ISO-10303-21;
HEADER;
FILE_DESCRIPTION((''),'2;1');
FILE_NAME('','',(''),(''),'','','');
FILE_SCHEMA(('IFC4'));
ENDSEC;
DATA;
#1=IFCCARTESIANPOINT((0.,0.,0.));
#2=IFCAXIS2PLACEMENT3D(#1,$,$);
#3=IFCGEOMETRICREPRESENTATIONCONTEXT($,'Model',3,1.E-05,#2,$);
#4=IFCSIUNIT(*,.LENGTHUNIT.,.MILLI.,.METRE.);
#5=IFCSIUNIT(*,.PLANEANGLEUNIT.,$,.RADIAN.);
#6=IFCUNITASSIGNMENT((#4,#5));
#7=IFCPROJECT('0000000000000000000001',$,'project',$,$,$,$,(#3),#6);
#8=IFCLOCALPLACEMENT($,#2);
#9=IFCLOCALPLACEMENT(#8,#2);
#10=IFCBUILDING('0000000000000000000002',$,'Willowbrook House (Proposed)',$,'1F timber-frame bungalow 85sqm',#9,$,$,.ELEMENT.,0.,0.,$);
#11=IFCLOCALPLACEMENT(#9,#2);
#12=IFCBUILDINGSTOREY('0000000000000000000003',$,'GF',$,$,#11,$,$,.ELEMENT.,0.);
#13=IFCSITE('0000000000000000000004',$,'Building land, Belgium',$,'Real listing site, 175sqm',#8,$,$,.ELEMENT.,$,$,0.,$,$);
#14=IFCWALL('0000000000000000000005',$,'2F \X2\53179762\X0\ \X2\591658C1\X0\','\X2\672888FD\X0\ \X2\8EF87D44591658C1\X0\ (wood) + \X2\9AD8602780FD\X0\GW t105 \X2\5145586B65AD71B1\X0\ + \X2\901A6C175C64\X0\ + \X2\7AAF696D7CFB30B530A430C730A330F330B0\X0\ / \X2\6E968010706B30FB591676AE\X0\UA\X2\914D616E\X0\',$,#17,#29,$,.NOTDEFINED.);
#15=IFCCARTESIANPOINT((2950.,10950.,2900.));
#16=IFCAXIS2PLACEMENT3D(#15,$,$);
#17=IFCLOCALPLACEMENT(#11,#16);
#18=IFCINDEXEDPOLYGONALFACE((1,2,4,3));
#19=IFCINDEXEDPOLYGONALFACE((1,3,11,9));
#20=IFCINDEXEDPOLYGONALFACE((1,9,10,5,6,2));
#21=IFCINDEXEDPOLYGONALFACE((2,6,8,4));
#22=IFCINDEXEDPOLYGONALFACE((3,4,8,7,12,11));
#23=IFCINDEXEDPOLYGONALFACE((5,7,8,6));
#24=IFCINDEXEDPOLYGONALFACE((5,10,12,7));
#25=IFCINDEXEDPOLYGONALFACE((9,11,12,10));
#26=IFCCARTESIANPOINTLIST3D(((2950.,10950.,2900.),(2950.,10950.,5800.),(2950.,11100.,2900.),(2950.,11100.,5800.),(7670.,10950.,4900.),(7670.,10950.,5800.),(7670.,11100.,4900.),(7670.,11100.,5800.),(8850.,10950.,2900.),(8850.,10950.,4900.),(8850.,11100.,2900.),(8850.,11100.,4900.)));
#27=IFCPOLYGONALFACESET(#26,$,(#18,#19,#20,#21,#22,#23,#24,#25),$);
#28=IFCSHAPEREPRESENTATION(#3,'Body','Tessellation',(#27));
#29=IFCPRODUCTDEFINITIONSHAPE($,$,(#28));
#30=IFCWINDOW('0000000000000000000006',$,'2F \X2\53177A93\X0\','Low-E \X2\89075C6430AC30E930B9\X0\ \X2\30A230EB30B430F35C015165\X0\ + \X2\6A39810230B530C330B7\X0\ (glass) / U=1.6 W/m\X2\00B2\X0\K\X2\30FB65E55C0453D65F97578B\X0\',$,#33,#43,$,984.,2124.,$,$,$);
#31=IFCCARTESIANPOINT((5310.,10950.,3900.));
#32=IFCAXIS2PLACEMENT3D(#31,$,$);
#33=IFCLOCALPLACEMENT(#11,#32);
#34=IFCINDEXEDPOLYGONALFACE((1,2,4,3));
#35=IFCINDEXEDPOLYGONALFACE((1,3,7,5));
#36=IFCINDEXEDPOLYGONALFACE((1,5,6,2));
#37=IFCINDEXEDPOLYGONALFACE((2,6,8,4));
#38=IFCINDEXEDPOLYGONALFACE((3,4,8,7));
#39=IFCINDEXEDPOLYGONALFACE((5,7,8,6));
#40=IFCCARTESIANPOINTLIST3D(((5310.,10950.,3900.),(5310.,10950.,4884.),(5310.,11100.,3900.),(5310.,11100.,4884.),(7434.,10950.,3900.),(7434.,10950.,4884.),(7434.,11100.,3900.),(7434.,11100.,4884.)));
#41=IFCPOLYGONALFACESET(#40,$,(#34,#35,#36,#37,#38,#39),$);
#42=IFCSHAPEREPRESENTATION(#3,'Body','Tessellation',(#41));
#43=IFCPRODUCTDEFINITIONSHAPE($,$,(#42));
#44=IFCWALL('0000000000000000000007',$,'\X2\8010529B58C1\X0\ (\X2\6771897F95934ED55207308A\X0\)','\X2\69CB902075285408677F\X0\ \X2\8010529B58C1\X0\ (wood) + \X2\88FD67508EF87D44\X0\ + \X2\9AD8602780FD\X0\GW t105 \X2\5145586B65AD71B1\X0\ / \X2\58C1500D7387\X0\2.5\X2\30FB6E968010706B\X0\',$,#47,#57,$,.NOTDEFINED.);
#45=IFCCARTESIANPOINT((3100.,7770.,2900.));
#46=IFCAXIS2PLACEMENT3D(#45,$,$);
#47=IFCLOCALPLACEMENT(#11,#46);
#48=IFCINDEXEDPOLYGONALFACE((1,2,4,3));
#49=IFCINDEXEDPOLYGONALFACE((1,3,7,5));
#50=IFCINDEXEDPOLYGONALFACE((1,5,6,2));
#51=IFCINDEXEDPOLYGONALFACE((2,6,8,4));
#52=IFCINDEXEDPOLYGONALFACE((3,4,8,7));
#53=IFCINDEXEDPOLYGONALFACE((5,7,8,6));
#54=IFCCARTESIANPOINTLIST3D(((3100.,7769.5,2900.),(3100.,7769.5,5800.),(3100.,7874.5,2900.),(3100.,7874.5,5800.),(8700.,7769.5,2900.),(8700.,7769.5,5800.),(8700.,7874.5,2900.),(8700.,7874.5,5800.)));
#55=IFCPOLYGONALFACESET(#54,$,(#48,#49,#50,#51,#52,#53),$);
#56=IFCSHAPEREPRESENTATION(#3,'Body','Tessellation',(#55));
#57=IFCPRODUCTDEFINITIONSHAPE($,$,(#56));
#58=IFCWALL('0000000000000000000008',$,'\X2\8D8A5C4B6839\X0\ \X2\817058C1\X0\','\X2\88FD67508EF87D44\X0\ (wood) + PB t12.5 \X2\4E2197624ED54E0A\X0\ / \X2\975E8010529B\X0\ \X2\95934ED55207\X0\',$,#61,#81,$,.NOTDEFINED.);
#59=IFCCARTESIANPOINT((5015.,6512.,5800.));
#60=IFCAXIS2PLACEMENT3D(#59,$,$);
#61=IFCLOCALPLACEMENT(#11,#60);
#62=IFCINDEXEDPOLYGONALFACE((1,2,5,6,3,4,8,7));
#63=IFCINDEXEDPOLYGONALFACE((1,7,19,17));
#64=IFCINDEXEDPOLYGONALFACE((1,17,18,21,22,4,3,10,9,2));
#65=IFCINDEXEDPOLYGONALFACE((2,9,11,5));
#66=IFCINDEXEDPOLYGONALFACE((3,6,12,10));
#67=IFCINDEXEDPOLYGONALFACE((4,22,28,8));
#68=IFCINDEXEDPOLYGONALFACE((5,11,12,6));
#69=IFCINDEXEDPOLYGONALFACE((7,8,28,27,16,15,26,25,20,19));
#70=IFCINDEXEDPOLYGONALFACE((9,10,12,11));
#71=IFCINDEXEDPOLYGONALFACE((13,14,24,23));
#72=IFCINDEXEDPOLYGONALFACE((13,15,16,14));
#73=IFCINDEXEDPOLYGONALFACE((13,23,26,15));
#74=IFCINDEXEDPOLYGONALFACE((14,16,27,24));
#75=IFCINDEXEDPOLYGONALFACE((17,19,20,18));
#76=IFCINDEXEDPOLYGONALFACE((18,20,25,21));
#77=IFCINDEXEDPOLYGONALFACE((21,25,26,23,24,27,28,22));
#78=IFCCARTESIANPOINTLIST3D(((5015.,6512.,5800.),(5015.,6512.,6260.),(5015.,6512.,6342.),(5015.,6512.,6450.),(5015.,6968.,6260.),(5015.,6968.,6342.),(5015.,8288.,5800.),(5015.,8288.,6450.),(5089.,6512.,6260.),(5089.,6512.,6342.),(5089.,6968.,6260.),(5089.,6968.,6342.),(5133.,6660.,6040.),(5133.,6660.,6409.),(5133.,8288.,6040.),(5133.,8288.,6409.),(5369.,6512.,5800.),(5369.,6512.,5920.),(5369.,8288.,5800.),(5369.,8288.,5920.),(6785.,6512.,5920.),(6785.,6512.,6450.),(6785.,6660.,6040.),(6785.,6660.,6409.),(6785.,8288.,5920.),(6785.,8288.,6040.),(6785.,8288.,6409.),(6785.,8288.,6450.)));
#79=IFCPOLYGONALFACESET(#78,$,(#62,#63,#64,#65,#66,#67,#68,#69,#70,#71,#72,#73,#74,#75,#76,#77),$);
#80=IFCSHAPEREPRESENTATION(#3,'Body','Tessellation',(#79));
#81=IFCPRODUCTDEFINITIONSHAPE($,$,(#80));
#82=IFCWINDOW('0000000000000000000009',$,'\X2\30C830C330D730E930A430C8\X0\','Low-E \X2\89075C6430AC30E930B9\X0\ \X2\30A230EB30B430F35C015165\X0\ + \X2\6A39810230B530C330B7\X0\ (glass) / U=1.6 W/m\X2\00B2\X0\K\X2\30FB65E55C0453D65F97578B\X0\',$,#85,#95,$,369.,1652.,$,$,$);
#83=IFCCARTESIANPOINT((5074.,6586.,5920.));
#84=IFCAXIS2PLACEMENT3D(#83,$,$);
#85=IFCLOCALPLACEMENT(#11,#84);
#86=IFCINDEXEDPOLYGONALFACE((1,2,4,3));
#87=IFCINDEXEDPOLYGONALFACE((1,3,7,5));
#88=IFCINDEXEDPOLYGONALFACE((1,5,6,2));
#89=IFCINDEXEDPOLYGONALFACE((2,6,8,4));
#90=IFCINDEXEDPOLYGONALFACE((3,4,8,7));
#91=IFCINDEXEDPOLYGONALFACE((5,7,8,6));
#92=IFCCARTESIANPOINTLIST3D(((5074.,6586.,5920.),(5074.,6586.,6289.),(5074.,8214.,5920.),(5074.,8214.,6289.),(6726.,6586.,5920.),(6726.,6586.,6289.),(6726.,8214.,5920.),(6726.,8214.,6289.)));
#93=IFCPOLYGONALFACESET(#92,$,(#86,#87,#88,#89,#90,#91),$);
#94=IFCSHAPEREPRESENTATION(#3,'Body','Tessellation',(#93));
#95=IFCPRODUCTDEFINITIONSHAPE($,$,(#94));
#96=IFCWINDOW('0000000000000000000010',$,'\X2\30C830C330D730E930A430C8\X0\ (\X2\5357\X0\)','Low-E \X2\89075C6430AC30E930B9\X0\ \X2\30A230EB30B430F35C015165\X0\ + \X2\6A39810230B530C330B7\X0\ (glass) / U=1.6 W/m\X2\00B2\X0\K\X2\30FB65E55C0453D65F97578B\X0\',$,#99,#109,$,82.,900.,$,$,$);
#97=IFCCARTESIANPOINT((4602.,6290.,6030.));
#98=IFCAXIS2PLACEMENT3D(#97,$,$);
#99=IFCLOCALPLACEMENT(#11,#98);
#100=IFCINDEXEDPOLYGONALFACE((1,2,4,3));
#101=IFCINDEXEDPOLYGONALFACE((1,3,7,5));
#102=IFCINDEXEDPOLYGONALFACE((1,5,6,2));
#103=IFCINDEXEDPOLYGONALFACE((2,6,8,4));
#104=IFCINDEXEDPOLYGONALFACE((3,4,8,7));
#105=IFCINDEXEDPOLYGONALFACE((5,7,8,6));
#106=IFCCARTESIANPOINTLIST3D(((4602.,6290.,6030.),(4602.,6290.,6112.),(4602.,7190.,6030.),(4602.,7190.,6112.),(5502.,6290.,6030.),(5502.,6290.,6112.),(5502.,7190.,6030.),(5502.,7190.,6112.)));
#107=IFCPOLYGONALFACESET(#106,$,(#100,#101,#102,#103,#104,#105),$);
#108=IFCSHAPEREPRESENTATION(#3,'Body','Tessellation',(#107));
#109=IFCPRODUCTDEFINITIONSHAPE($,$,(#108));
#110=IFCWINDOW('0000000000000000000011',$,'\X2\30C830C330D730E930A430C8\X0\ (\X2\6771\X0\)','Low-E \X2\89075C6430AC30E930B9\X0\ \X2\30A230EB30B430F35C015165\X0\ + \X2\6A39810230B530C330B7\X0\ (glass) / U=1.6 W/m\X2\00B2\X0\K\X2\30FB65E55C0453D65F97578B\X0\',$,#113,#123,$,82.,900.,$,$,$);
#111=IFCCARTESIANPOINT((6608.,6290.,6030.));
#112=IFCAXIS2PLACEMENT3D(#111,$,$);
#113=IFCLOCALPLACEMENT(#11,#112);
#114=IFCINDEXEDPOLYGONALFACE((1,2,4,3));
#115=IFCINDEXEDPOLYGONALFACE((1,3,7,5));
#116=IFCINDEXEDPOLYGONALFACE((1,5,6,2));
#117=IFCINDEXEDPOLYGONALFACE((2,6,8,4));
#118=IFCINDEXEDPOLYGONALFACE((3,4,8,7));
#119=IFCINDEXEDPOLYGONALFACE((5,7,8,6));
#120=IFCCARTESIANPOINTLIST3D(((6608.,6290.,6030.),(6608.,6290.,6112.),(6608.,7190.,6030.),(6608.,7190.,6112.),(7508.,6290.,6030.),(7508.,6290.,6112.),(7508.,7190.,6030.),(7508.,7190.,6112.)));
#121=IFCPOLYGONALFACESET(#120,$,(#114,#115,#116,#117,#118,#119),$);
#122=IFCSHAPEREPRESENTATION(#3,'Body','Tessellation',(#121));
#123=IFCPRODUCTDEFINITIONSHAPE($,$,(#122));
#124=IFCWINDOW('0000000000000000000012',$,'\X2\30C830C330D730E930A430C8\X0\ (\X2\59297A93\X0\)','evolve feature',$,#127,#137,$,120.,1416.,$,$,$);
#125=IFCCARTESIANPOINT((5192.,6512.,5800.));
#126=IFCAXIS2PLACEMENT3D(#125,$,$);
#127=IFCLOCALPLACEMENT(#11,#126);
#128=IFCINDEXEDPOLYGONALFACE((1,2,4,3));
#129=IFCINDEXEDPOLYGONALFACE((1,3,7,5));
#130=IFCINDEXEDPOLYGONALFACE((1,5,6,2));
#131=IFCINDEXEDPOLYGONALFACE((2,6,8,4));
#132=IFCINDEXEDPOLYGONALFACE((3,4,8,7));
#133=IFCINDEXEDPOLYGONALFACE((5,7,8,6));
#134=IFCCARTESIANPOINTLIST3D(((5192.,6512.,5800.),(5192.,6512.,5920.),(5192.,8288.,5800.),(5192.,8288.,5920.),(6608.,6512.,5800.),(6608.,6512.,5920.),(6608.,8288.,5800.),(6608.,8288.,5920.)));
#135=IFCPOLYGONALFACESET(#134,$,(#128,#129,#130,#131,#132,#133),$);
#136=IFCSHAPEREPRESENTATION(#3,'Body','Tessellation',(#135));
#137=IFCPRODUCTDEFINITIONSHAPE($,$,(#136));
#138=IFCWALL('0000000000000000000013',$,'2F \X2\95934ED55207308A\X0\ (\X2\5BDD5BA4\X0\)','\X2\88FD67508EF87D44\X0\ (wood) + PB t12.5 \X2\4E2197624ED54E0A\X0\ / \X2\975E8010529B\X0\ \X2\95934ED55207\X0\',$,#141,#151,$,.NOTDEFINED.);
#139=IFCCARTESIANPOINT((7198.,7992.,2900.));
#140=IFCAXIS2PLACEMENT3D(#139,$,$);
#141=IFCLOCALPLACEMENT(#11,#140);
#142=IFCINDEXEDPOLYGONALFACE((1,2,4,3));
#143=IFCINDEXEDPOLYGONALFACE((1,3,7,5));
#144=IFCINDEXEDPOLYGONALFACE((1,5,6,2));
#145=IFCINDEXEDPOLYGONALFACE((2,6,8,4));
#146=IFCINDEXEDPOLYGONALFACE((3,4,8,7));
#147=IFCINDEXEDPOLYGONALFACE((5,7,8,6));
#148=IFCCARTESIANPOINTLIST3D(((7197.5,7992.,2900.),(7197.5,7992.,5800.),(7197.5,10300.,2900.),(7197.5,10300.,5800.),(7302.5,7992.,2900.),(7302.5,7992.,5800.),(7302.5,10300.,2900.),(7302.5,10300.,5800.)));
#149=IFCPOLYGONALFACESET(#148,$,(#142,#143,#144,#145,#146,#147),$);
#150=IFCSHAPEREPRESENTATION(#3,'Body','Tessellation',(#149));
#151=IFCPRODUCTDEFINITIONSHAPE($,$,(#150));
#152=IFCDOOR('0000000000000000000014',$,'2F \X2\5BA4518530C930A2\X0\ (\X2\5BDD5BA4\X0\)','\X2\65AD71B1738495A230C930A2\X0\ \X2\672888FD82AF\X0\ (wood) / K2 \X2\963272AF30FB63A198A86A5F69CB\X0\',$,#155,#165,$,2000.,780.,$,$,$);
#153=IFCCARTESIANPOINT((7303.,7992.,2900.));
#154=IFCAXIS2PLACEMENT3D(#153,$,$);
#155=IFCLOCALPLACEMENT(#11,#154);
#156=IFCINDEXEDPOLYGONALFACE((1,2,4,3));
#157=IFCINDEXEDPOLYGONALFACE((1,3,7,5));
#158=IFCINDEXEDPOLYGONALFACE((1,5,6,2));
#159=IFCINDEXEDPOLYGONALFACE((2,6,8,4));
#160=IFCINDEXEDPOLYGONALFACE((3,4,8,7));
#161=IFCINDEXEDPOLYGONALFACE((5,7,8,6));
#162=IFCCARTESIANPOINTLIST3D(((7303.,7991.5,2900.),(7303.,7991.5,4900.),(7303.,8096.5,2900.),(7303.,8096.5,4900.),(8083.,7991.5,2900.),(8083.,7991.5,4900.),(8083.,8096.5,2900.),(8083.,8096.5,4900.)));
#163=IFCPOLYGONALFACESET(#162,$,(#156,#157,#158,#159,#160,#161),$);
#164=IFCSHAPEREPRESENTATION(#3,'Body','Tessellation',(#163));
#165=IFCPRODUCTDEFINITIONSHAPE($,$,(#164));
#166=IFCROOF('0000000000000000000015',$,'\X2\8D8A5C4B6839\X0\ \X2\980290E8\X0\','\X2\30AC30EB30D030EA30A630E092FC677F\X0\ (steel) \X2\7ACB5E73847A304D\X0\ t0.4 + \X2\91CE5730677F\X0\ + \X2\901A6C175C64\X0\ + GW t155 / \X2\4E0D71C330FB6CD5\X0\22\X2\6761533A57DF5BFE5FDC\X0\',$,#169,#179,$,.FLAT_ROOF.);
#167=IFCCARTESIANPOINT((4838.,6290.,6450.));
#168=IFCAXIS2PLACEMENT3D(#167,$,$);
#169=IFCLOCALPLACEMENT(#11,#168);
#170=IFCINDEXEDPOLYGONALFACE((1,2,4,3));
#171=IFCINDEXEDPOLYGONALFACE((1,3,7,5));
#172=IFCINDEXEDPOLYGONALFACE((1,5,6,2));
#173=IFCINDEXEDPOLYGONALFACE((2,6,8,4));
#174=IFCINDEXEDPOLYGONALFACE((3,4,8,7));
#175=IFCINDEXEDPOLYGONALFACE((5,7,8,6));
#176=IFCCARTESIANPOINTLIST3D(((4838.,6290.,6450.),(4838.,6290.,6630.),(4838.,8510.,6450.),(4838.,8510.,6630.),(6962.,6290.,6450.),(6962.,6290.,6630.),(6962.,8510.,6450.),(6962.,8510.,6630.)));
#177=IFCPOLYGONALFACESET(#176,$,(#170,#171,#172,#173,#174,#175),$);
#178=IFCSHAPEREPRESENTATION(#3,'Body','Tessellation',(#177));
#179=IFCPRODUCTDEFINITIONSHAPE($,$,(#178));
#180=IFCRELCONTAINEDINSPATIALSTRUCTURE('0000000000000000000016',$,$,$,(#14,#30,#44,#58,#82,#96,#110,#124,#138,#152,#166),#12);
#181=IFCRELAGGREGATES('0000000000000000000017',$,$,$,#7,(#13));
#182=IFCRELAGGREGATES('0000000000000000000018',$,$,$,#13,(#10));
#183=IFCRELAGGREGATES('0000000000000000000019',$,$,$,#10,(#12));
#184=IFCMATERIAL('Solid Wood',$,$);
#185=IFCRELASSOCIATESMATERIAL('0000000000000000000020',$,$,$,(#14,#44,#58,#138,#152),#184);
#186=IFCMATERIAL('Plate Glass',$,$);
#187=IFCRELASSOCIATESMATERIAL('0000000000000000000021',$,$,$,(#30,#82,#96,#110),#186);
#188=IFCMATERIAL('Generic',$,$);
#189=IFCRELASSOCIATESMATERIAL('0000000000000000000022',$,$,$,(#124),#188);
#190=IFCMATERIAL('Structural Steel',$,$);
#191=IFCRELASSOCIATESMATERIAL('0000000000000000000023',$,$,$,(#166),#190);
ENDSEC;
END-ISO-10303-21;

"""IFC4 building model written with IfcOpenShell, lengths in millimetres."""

from ifc_helpers import new_model, si_unit, frame, frame_2d, origin, place, context, project, spatial, rectangle, extrude, material, element, fill, save


model = new_model("IFC4")

# Units and contexts
model_context = context("Model", 3, precision=1e-05, world=origin())
ifc_project = project(units=[si_unit("LENGTHUNIT", "METRE", prefix="MILLI"), si_unit("PLANEANGLEUNIT", "RADIAN")], contexts=[model_context])

# Site, building, storey
site_placement = place(None, origin())
site = spatial("IfcSite", under=ifc_project, at=site_placement, Name="Building land, Belgium", ObjectType="Real listing site, 175sqm", CompositionType="ELEMENT", RefElevation=0.0)
building_placement = place(site_placement, origin())
building = spatial("IfcBuilding", under=site, at=building_placement, Name="Willowbrook House (Proposed)", ObjectType="1F timber-frame bungalow 85sqm", CompositionType="ELEMENT", ElevationOfRefHeight=0.0, ElevationOfTerrain=0.0)
storey_placement = place(building_placement, origin())
storey = spatial("IfcBuildingStorey", under=building, at=storey_placement, Name="GF", CompositionType="ELEMENT", Elevation=0.0)

# Wall, opening, window
ifc_material_1 = material(Name="Solid Wood")
wall_1_placement = place(storey_placement, frame((2950.0, 10950.0, 2900.0)))
wall_1 = element("IfcWall", 1, at=wall_1_placement, inside=storey, material=ifc_material_1, Name="2F 北面 外壁", Description="木製 軸組外壁 (wood) + 高性能GW t105 充填断熱 + 通気層 + 窯業系サイディング / 準耐火・外皮UA配慮", PredefinedType="NOTDEFINED", context=model_context, shape_type="SweptSolid", body=[
    extrude(rectangle(XDim=5900.0, YDim=150.0, at=frame_2d((2950.0, 75.0))), frame((2950.0, 10950.0, 2900.0)), (0.0, 0.0, 1.0), 2900.0),
])
opening_1_placement = place(storey_placement, frame((5310.0, 10950.0, 3900.0)))
opening_1 = element("IfcOpeningElement", 2, at=opening_1_placement, cuts=wall_1, PredefinedType="NOTDEFINED", context=model_context, shape_type="SweptSolid", body=[
    extrude(rectangle(XDim=2124.0, YDim=150.0, at=frame_2d((1062.0, 75.0))), frame((5310.0, 10950.0, 3900.0)), (0.0, 0.0, 1.0), 984.0),
])
ifc_material_2 = material(Name="Plate Glass")
window_1_placement = place(storey_placement, frame((5310.0, 10950.0, 3900.0)))
window_1 = element("IfcWindow", 3, at=window_1_placement, inside=storey, material=ifc_material_2, Name="2F 北窓", Description="Low-E 複層ガラス アルゴン封入 + 樹脂サッシ (glass) / U=1.6 W/m²K・日射取得型", OverallHeight=984.0, OverallWidth=2124.0, context=model_context, shape_type="SweptSolid", body=[
    extrude(rectangle(XDim=2124.0, YDim=150.0, at=frame_2d((1062.0, 75.0))), frame((5310.0, 10950.0, 3900.0)), (0.0, 0.0, 1.0), 984.0),
])
fill(opening_1, window_1)

# Wall
wall_2_placement = place(storey_placement, frame((3100.0, 7770.0, 2900.0)))
element("IfcWall", 4, at=wall_2_placement, inside=storey, material=ifc_material_1, Name="耐力壁 (東西間仕切り)", Description="構造用合板 耐力壁 (wood) + 製材軸組 + 高性能GW t105 充填断熱 / 壁倍率2.5・準耐火", PredefinedType="NOTDEFINED", context=model_context, shape_type="SweptSolid", body=[
    extrude(rectangle(XDim=5600.0, YDim=105.0, at=frame_2d((2800.0, 52.0))), frame((3100.0, 7770.0, 2900.0)), (0.0, 0.0, 1.0), 2900.0),
])

# Wall, openings, windows
wall_3_placement = place(storey_placement, frame((5015.0, 6512.0, 5800.0)))
wall_3 = element("IfcWall", 5, at=wall_3_placement, inside=storey, material=ifc_material_1, Name="越屋根 腰壁", Description="製材軸組 (wood) + PB t12.5 両面仕上 / 非耐力 間仕切", PredefinedType="NOTDEFINED", context=model_context, shape_type="SweptSolid", body=[
    extrude(rectangle(XDim=1770.0, YDim=1776.0, at=frame_2d((885.0, 888.0))), frame((5015.0, 6512.0, 5800.0)), (0.0, 0.0, 1.0), 650.0),
])
opening_2_placement = place(storey_placement, frame((5074.0, 6586.0, 5920.0)))
opening_2 = element("IfcOpeningElement", 6, at=opening_2_placement, cuts=wall_3, PredefinedType="NOTDEFINED", context=model_context, shape_type="SweptSolid", body=[
    extrude(rectangle(XDim=1652.0, YDim=1628.0, at=frame_2d((826.0, 814.0))), frame((5074.0, 6586.0, 5920.0)), (0.0, 0.0, 1.0), 369.0),
])
opening_3_placement = place(storey_placement, frame((4602.0, 6290.0, 6030.0)))
opening_3 = element("IfcOpeningElement", 7, at=opening_3_placement, cuts=wall_3, PredefinedType="NOTDEFINED", context=model_context, shape_type="SweptSolid", body=[
    extrude(rectangle(XDim=900.0, YDim=900.0, at=frame_2d((450.0, 450.0))), frame((4602.0, 6290.0, 6030.0)), (0.0, 0.0, 1.0), 82.0),
])
opening_4_placement = place(storey_placement, frame((6608.0, 6290.0, 6030.0)))
opening_4 = element("IfcOpeningElement", 8, at=opening_4_placement, cuts=wall_3, PredefinedType="NOTDEFINED", context=model_context, shape_type="SweptSolid", body=[
    extrude(rectangle(XDim=900.0, YDim=900.0, at=frame_2d((450.0, 450.0))), frame((6608.0, 6290.0, 6030.0)), (0.0, 0.0, 1.0), 82.0),
])
opening_5_placement = place(storey_placement, frame((5192.0, 6512.0, 5800.0)))
opening_5 = element("IfcOpeningElement", 9, at=opening_5_placement, cuts=wall_3, PredefinedType="NOTDEFINED", context=model_context, shape_type="SweptSolid", body=[
    extrude(rectangle(XDim=1416.0, YDim=1776.0, at=frame_2d((708.0, 888.0))), frame((5192.0, 6512.0, 5800.0)), (0.0, 0.0, 1.0), 120.0),
])
window_2_placement = place(storey_placement, frame((5074.0, 6586.0, 5920.0)))
window_2 = element("IfcWindow", 10, at=window_2_placement, inside=storey, material=ifc_material_2, Name="トップライト", Description="Low-E 複層ガラス アルゴン封入 + 樹脂サッシ (glass) / U=1.6 W/m²K・日射取得型", OverallHeight=369.0, OverallWidth=1652.0, context=model_context, shape_type="SweptSolid", body=[
    extrude(rectangle(XDim=1652.0, YDim=1628.0, at=frame_2d((826.0, 814.0))), frame((5074.0, 6586.0, 5920.0)), (0.0, 0.0, 1.0), 369.0),
])
fill(opening_2, window_2)
window_3_placement = place(storey_placement, frame((4602.0, 6290.0, 6030.0)))
window_3 = element("IfcWindow", 11, at=window_3_placement, inside=storey, material=ifc_material_2, Name="トップライト (南)", Description="Low-E 複層ガラス アルゴン封入 + 樹脂サッシ (glass) / U=1.6 W/m²K・日射取得型", OverallHeight=82.0, OverallWidth=900.0, context=model_context, shape_type="SweptSolid", body=[
    extrude(rectangle(XDim=900.0, YDim=900.0, at=frame_2d((450.0, 450.0))), frame((4602.0, 6290.0, 6030.0)), (0.0, 0.0, 1.0), 82.0),
])
fill(opening_3, window_3)
window_4_placement = place(storey_placement, frame((6608.0, 6290.0, 6030.0)))
window_4 = element("IfcWindow", 12, at=window_4_placement, inside=storey, material=ifc_material_2, Name="トップライト (東)", Description="Low-E 複層ガラス アルゴン封入 + 樹脂サッシ (glass) / U=1.6 W/m²K・日射取得型", OverallHeight=82.0, OverallWidth=900.0, context=model_context, shape_type="SweptSolid", body=[
    extrude(rectangle(XDim=900.0, YDim=900.0, at=frame_2d((450.0, 450.0))), frame((6608.0, 6290.0, 6030.0)), (0.0, 0.0, 1.0), 82.0),
])
fill(opening_4, window_4)
ifc_material_3 = material(Name="Generic")
window_5_placement = place(storey_placement, frame((5192.0, 6512.0, 5800.0)))
window_5 = element("IfcWindow", 13, at=window_5_placement, inside=storey, material=ifc_material_3, Name="トップライト (天窓)", Description="evolve feature", OverallHeight=120.0, OverallWidth=1416.0, context=model_context, shape_type="SweptSolid", body=[
    extrude(rectangle(XDim=1416.0, YDim=1776.0, at=frame_2d((708.0, 888.0))), frame((5192.0, 6512.0, 5800.0)), (0.0, 0.0, 1.0), 120.0),
])
fill(opening_5, window_5)

# Wall
wall_4_placement = place(storey_placement, frame((7198.0, 7992.0, 2900.0)))
element("IfcWall", 14, at=wall_4_placement, inside=storey, material=ifc_material_1, Name="2F 間仕切り (寝室)", Description="製材軸組 (wood) + PB t12.5 両面仕上 / 非耐力 間仕切", PredefinedType="NOTDEFINED", context=model_context, shape_type="SweptSolid", body=[
    extrude(rectangle(XDim=105.0, YDim=2308.0, at=frame_2d((52.0, 1154.0))), frame((7198.0, 7992.0, 2900.0)), (0.0, 0.0, 1.0), 2900.0),
])

# Door
door_placement = place(storey_placement, frame((7303.0, 7992.0, 2900.0)))
element("IfcDoor", 15, at=door_placement, inside=storey, material=ifc_material_1, Name="2F 室内ドア (寝室)", Description="断熱玄関ドア 木製芯 (wood) / K2 防犯・採風機構", OverallHeight=2000.0, OverallWidth=780.0, context=model_context, shape_type="SweptSolid", body=[
    extrude(rectangle(XDim=780.0, YDim=105.0, at=frame_2d((390.0, 52.0))), frame((7303.0, 7992.0, 2900.0)), (0.0, 0.0, 1.0), 2000.0),
])

# Roof
ifc_material_4 = material(Name="Structural Steel")
roof_placement = place(storey_placement, frame((4838.0, 6290.0, 6450.0)))
element("IfcRoof", 16, at=roof_placement, inside=storey, material=ifc_material_4, Name="越屋根 頂部", Description="ガルバリウム鋼板 (steel) 立平葺き t0.4 + 野地板 + 通気層 + GW t155 / 不燃・法22条区域対応", PredefinedType="FLAT_ROOF", context=model_context, shape_type="SweptSolid", body=[
    extrude(rectangle(XDim=2124.0, YDim=2220.0, at=frame_2d((1062.0, 1110.0))), frame((4838.0, 6290.0, 6450.0)), (0.0, 0.0, 1.0), 180.0),
])

save(model, "model.ifc")
